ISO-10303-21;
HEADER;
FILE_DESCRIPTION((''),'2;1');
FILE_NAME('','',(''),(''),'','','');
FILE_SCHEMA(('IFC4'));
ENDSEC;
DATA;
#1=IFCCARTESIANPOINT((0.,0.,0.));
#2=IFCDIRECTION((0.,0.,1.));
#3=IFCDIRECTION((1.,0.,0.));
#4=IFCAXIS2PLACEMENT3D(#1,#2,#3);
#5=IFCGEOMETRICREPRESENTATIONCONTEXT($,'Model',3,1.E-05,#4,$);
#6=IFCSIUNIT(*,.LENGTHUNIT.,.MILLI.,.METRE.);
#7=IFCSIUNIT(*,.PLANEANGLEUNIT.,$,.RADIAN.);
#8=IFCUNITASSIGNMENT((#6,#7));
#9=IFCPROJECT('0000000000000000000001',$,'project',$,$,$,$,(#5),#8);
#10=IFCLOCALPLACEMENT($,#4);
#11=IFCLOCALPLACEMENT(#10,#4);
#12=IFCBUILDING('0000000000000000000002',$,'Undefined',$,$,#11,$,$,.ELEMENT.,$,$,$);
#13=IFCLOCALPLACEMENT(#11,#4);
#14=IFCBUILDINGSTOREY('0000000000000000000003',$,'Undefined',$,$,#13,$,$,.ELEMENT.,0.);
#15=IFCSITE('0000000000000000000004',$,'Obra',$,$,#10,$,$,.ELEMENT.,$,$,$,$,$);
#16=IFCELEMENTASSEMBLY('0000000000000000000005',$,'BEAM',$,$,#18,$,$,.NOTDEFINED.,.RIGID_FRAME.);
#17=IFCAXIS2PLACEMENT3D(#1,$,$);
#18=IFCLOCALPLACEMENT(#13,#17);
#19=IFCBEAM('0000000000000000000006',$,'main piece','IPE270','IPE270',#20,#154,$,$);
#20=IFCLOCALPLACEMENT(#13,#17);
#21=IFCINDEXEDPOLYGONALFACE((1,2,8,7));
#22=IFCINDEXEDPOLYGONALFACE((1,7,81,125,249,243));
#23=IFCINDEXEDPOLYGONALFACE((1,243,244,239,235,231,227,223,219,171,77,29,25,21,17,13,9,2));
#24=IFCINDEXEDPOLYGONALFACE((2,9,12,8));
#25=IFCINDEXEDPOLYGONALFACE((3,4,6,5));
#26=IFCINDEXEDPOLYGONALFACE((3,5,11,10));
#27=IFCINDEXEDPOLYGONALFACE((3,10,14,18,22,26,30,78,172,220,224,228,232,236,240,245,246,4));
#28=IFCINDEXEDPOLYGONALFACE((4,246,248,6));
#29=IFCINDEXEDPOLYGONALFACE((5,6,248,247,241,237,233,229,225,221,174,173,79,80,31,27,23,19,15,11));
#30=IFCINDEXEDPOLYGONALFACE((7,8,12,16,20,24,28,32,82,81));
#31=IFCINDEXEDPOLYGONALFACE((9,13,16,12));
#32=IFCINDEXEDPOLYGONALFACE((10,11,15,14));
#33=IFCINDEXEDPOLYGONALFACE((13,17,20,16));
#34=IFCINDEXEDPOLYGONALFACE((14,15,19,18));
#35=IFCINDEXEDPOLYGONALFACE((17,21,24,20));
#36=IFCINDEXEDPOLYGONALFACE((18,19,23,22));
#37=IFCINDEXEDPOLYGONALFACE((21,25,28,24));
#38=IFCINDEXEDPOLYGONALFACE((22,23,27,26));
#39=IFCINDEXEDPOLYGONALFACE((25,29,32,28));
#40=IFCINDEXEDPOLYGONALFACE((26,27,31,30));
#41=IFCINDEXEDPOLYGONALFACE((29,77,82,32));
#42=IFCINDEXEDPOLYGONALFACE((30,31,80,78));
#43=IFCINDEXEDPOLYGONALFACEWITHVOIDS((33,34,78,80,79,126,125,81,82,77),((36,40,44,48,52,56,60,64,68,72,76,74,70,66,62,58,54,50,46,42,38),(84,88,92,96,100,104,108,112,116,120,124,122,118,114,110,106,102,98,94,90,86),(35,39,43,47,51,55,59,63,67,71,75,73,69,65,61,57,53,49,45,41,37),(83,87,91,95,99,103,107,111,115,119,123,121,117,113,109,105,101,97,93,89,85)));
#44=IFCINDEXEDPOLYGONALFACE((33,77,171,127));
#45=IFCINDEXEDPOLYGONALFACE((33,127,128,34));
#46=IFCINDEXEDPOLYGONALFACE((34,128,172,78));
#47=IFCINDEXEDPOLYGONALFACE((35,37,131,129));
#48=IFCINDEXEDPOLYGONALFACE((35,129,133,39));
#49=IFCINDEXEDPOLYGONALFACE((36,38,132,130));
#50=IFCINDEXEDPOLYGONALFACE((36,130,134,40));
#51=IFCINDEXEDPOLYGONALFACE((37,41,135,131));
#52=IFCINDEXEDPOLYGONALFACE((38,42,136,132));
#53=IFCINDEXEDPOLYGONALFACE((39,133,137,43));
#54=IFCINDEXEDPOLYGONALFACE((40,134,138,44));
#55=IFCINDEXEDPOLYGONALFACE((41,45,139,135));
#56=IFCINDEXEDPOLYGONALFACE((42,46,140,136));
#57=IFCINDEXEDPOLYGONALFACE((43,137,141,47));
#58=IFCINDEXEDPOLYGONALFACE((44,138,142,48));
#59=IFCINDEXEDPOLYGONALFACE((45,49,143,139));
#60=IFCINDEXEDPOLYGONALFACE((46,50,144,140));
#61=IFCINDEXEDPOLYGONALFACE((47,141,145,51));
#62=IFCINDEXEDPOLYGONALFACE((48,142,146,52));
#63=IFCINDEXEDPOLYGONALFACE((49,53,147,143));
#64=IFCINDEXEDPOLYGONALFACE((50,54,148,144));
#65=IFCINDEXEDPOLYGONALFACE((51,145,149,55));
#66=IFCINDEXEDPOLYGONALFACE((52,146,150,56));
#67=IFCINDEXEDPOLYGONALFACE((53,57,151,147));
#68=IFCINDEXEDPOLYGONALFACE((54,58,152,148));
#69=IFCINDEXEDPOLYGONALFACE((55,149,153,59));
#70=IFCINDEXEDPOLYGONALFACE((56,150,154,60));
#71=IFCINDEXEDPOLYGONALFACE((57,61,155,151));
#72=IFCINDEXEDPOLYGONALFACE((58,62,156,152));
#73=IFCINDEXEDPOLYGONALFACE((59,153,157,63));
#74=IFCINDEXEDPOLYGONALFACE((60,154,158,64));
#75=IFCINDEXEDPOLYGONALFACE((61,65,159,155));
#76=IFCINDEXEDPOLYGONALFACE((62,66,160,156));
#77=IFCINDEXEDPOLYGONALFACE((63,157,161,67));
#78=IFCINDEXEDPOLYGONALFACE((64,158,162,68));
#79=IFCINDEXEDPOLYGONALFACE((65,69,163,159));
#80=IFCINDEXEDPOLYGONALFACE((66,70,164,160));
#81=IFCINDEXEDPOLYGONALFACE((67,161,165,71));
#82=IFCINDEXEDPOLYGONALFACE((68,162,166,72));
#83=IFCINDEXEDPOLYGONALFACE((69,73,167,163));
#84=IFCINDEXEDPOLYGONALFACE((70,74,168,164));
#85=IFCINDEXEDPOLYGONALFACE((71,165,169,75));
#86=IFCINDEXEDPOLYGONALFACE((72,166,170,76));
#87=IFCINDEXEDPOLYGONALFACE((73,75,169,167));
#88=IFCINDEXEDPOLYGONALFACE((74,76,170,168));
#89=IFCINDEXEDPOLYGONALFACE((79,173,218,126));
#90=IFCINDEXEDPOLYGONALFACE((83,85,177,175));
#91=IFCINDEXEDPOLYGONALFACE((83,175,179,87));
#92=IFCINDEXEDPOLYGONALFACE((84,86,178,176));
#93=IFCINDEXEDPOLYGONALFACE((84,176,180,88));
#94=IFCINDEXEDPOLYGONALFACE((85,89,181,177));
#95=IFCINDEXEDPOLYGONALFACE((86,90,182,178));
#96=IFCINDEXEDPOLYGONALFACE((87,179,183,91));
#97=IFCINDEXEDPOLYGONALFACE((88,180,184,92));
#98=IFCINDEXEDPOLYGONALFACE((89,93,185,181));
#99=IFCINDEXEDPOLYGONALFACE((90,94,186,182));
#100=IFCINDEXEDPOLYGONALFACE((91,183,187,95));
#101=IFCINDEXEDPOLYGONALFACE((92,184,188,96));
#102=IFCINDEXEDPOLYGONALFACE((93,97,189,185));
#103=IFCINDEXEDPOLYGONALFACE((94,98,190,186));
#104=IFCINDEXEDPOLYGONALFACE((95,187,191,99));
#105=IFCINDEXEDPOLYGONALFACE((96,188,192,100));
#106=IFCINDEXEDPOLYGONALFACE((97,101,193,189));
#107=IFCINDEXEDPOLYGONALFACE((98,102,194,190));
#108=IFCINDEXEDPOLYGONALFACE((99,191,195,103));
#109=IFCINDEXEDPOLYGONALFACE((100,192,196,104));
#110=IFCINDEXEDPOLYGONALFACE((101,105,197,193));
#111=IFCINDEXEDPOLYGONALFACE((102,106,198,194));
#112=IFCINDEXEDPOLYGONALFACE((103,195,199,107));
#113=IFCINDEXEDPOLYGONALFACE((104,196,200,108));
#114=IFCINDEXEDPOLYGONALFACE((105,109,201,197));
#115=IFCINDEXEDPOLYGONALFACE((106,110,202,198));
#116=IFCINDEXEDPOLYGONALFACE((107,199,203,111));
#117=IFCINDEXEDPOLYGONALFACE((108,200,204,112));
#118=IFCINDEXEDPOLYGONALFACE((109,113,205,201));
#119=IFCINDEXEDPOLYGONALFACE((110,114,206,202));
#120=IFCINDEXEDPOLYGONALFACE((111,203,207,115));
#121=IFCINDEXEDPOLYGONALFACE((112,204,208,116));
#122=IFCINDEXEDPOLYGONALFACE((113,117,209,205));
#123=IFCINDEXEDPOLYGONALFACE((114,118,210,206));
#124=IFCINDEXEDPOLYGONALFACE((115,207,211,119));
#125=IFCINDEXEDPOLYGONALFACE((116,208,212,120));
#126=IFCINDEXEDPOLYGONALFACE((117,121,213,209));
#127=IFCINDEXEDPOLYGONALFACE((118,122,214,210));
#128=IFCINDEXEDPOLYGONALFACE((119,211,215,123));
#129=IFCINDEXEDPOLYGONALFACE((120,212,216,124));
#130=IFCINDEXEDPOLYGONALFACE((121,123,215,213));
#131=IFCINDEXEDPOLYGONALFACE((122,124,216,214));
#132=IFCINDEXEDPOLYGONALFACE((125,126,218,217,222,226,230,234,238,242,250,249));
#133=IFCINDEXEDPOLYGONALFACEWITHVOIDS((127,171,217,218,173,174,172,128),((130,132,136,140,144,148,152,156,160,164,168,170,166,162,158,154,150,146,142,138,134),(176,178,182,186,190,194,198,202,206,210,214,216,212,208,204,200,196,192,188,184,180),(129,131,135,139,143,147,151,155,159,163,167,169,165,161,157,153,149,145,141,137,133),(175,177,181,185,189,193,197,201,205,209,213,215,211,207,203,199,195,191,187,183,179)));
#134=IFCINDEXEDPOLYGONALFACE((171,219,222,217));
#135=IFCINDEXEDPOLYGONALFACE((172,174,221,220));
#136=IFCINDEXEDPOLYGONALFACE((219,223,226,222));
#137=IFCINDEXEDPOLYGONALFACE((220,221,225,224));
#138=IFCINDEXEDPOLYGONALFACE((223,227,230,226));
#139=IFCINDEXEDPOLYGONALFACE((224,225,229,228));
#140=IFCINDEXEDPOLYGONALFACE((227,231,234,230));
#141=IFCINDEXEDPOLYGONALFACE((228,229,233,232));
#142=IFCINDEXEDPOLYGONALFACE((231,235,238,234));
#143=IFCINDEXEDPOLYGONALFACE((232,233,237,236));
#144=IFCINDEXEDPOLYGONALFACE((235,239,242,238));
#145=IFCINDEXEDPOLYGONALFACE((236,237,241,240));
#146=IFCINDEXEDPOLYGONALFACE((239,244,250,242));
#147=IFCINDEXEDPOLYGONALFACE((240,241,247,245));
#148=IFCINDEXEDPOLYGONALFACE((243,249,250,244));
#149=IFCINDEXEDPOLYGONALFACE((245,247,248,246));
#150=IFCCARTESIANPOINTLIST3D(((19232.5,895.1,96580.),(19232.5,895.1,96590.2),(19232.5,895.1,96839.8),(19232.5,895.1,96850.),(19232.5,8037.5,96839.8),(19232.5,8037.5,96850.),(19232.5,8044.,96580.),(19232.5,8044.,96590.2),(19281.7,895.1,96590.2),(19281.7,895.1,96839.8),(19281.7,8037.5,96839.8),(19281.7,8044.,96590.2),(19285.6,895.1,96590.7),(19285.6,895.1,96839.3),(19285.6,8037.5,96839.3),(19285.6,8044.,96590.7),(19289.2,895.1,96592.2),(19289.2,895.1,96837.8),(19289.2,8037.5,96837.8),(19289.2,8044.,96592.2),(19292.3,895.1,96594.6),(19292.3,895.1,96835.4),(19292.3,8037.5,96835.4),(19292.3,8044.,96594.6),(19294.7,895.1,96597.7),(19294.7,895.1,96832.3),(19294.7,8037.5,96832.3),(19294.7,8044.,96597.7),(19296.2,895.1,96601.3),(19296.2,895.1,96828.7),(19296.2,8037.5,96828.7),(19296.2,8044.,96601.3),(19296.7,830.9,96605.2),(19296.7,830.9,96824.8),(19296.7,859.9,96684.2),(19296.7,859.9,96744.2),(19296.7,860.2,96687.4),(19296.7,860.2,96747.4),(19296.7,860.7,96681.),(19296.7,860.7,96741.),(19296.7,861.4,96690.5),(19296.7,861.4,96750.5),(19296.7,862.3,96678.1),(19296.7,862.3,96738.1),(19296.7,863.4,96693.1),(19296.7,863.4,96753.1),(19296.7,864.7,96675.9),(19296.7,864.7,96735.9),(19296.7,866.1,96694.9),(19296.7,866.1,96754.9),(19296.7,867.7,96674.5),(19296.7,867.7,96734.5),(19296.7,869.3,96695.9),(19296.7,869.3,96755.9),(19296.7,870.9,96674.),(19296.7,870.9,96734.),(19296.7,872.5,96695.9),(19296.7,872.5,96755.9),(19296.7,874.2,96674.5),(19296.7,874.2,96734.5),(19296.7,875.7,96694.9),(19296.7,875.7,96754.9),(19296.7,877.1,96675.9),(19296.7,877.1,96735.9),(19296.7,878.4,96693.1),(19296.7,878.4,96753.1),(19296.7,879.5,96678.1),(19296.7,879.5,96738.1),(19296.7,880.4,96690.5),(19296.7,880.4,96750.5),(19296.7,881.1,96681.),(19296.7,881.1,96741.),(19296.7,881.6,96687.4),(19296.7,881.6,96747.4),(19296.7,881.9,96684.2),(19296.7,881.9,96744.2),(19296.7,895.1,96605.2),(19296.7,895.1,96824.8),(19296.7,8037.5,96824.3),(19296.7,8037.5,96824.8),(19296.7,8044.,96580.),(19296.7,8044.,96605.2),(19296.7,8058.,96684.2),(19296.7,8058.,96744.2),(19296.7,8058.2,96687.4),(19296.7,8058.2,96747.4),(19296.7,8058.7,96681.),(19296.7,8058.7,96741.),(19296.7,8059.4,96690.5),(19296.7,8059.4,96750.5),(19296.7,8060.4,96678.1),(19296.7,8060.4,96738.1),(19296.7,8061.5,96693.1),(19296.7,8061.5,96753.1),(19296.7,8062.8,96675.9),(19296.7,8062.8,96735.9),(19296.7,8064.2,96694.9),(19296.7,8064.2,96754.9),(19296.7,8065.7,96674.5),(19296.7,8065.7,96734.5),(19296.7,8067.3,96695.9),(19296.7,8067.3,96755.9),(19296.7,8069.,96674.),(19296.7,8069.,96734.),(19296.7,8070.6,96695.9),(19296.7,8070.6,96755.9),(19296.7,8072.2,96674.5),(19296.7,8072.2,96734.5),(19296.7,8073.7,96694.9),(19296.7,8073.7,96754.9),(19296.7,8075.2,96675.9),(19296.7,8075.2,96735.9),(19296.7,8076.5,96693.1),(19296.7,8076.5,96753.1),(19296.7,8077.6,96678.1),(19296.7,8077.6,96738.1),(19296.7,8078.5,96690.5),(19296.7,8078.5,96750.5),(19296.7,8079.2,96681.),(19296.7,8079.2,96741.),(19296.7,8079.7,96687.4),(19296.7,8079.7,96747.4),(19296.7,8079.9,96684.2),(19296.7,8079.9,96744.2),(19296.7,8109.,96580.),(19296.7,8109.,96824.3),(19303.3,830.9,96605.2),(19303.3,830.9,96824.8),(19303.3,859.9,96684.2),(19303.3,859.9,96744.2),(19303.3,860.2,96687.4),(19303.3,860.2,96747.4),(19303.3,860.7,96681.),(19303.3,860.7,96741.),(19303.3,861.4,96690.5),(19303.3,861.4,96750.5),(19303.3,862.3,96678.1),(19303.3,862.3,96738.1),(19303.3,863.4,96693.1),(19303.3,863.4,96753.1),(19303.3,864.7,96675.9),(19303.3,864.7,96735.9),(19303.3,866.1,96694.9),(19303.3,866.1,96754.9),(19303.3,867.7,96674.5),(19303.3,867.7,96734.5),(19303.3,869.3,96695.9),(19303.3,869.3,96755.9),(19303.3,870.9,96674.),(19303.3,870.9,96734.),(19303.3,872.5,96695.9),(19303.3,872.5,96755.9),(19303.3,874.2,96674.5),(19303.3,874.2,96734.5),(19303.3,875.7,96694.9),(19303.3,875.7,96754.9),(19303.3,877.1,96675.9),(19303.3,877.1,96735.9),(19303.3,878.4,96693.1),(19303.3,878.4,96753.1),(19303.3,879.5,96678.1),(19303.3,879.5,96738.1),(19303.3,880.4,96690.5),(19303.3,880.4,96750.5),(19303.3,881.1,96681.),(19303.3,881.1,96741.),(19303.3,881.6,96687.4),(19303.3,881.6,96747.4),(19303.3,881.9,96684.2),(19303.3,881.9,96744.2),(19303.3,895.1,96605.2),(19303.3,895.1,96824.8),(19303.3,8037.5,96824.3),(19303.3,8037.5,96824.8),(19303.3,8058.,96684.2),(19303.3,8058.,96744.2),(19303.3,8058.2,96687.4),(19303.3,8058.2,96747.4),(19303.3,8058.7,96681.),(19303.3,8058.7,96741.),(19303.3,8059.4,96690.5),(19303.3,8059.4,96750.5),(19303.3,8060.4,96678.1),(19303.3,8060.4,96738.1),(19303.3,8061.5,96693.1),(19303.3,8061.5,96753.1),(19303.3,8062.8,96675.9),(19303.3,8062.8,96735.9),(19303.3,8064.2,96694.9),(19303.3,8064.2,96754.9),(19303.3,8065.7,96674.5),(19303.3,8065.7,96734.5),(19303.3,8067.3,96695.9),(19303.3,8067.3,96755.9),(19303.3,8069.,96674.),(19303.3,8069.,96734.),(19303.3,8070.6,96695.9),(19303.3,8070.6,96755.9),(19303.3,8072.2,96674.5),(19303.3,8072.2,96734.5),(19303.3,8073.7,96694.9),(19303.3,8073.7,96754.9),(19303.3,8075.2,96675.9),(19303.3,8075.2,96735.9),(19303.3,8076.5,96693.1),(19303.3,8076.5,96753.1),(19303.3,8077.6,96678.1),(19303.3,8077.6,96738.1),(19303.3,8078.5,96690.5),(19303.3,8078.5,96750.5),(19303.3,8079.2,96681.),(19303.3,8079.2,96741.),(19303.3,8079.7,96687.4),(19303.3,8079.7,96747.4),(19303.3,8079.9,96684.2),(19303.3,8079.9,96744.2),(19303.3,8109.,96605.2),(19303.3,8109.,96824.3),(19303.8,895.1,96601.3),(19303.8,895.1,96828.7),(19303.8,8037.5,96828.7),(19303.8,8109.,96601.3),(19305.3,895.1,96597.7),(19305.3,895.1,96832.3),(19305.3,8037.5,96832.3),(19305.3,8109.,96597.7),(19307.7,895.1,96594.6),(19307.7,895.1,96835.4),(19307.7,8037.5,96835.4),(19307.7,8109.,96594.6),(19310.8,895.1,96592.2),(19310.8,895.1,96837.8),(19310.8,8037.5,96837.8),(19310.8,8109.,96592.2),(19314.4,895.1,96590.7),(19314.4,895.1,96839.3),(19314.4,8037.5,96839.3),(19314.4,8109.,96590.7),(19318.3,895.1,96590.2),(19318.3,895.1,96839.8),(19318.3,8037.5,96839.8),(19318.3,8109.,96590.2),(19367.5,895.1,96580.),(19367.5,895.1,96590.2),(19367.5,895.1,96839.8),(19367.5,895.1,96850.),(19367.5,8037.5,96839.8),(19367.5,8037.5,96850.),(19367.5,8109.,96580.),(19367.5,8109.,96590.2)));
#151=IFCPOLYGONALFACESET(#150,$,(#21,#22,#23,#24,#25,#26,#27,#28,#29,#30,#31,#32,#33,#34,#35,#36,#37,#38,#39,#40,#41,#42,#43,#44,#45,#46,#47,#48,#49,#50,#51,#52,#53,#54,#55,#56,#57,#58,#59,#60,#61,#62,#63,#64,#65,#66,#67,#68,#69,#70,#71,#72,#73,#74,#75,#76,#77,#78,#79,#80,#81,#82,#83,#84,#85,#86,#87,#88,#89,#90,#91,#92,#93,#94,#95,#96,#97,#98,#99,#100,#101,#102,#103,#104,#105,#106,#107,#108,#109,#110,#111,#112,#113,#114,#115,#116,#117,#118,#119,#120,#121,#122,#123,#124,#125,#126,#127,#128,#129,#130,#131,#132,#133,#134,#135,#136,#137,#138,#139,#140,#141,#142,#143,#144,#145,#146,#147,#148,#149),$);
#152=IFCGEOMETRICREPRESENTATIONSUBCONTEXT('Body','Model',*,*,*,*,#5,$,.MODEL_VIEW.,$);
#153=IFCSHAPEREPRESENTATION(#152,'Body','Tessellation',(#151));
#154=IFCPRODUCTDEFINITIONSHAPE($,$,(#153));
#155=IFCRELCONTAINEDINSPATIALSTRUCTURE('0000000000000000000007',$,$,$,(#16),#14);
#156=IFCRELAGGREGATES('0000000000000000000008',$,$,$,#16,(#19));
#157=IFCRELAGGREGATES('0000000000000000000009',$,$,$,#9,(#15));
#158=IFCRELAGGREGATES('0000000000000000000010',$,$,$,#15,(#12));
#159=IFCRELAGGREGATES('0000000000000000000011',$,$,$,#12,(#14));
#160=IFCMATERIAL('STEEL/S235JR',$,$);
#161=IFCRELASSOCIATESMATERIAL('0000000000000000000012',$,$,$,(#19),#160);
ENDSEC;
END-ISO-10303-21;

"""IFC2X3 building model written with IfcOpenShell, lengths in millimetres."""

from ifc_helpers import new_model, si_unit, frame, origin_with_axes, origin_2d_with_axis, place, context, subcontext, project, spatial, rectangle, circle, i_section, extrude, clip, halfspace, source, transform, mapped, material, element, aggregate, save


model = new_model("IFC2X3")

# Units and contexts
model_context = context("Model", 3, precision=1e-05, world=origin_with_axes())
body_context = subcontext(model_context, "Body", "Model", "MODEL_VIEW")
ifc_project = project(units=[si_unit("LENGTHUNIT", "METRE", prefix="MILLI"), si_unit("PLANEANGLEUNIT", "RADIAN")], contexts=[model_context])

# Site, building, storey
site_placement = place(None, origin_with_axes())
site = spatial("IfcSite", under=ifc_project, at=site_placement, Name="Obra", CompositionType="ELEMENT")
building_placement = place(site_placement, origin_with_axes())
building = spatial("IfcBuilding", under=site, at=building_placement, Name="Undefined", CompositionType="ELEMENT")
storey_placement = place(building_placement, origin_with_axes())
storey = spatial("IfcBuildingStorey", under=building, at=storey_placement, Name="Undefined", CompositionType="ELEMENT", Elevation=0.0)

# Shared definitions
ifc_material = material(Name="STEEL/S235JR")

# Element assembly, beam, openings
shared_shape = source(origin_with_axes(), body_context, "Body", "SweptSolid", [
    extrude(circle(Radius=11.0, at=origin_2d_with_axis()), frame((0.0, -3.4, 0.0), z_axis=(0.0, 1.0, 0.0), x_axis=(1.0, 0.0, 0.0)), (0.0, 0.0, 1.0), 6.8),
])
assembly_1_placement = place(storey_placement, origin_with_axes())
assembly_1 = element("IfcElementAssembly", 1, at=assembly_1_placement, inside=storey, Name="BEAM", AssemblyPlace="NOTDEFINED", PredefinedType="RIGID_FRAME")
beam_1_placement = place(assembly_1_placement, frame((19300.0, 905.1, 96715.0), z_axis=(0.0, 0.0, 1.0), x_axis=(0.0, 1.0, 0.0)))
beam_1 = element("IfcBeam", 2, at=beam_1_placement, material=ifc_material, Name="main piece", Description="IPE270", ObjectType="IPE270", context=body_context, shape_type="Clipping", body=[
    clip(clip(extrude(i_section(OverallWidth=135.0, OverallDepth=270.0, WebThickness=6.6, FlangeThickness=10.2, FilletRadius=15.0, at=origin_2d_with_axis()), frame((7203.9, 0.0, 0.0), z_axis=(-1.0, 0.0, 0.0), x_axis=(0.0, -1.0, 0.0)), (0.0, 0.0, 1.0), 7278.1), halfspace(frame((7203.9, 0.0, -235.0), z_axis=(-1.0, 0.0, 0.0), x_axis=(0.0, 1.0, 0.0)), True)), halfspace(frame((-74.2, 0.0, -235.0), z_axis=(1.0, 0.0, 0.0), x_axis=(0.0, -1.0, 0.0)), True)),
])
opening_1_placement = place(assembly_1_placement, frame((19300.0, 905.1, 96715.0), z_axis=(0.0, 0.0, 1.0), x_axis=(0.0, 1.0, 0.0)))
element("IfcOpeningElement", 3, at=opening_1_placement, cuts=beam_1, ObjectType="Recess", context=body_context, shape_type="SweptSolid", body=[
    extrude(rectangle(XDim=75.0, YDim=300.0, at=origin_2d_with_axis()), frame((7176.4, 153.3, 124.3), z_axis=(0.0, 0.0, -1.0), x_axis=(-1.0, 0.0, 0.0)), (0.0, 0.0, 1.0), 278.6),
])
opening_2_placement = place(assembly_1_placement, frame((19300.0, 905.1, 96715.0), z_axis=(0.0, 0.0, 1.0), x_axis=(0.0, 1.0, 0.0)))
element("IfcOpeningElement", 4, at=opening_2_placement, cuts=beam_1, ObjectType="Recess", context=body_context, shape_type="SweptSolid", body=[
    extrude(rectangle(XDim=26.7, YDim=83.5, at=origin_2d_with_axis()), frame((7174.1, 68.5, 122.7), z_axis=(0.0, -1.0, 0.0), x_axis=(0.0, 0.0, -1.0)), (0.0, 0.0, 1.0), 137.0),
])
opening_3_placement = place(assembly_1_placement, frame((19300.0, 905.1, 96715.0), z_axis=(0.0, 0.0, 1.0), x_axis=(0.0, 1.0, 0.0)))
element("IfcOpeningElement", 5, at=opening_3_placement, cuts=beam_1, ObjectType="Recess", context=body_context, shape_type="SweptSolid", body=[
    extrude(rectangle(XDim=26.2, YDim=76.2, at=origin_2d_with_axis()), frame((-48.1, -68.5, -122.9), z_axis=(0.0, 1.0, 0.0), x_axis=(0.0, 0.0, -1.0)), (0.0, 0.0, 1.0), 137.0),
])
opening_4_placement = place(assembly_1_placement, frame((19300.0, 905.1, 96715.0), z_axis=(0.0, 0.0, 1.0), x_axis=(0.0, 1.0, 0.0)))
element("IfcOpeningElement", 6, at=opening_4_placement, cuts=beam_1, ObjectType="Recess", context=body_context, shape_type="SweptSolid", body=[
    extrude(rectangle(XDim=26.2, YDim=76.2, at=origin_2d_with_axis()), frame((-48.1, -68.5, 122.9), z_axis=(0.0, 1.0, 0.0), x_axis=(0.0, 0.0, -1.0)), (0.0, 0.0, 1.0), 137.0),
])
opening_5_placement = place(assembly_1_placement, frame((19300.0, 8109.0, 96850.0), z_axis=(0.0, -1.0, 0.0), x_axis=(0.0, 0.0, -1.0)))
element("IfcOpeningElement", 7, at=opening_5_placement, cuts=beam_1, ObjectType="Opening", context=body_context, shape_type="MappedRepresentation", body=[
    mapped(shared_shape, transform((105.0, 0.0, 40.0))),
    mapped(shared_shape, transform((165.0, 0.0, 40.0))),
])
opening_6_placement = place(assembly_1_placement, frame((19300.0, 830.9, 96850.0), z_axis=(0.0, 1.0, 0.0), x_axis=(0.0, 0.0, -1.0)))
element("IfcOpeningElement", 8, at=opening_6_placement, cuts=beam_1, ObjectType="Opening", context=body_context, shape_type="MappedRepresentation", body=[
    mapped(shared_shape, transform((105.0, 0.0, 40.0))),
    mapped(shared_shape, transform((165.0, 0.0, 40.0))),
])
aggregate(assembly_1, [beam_1])

save(model, "model.ifc")
